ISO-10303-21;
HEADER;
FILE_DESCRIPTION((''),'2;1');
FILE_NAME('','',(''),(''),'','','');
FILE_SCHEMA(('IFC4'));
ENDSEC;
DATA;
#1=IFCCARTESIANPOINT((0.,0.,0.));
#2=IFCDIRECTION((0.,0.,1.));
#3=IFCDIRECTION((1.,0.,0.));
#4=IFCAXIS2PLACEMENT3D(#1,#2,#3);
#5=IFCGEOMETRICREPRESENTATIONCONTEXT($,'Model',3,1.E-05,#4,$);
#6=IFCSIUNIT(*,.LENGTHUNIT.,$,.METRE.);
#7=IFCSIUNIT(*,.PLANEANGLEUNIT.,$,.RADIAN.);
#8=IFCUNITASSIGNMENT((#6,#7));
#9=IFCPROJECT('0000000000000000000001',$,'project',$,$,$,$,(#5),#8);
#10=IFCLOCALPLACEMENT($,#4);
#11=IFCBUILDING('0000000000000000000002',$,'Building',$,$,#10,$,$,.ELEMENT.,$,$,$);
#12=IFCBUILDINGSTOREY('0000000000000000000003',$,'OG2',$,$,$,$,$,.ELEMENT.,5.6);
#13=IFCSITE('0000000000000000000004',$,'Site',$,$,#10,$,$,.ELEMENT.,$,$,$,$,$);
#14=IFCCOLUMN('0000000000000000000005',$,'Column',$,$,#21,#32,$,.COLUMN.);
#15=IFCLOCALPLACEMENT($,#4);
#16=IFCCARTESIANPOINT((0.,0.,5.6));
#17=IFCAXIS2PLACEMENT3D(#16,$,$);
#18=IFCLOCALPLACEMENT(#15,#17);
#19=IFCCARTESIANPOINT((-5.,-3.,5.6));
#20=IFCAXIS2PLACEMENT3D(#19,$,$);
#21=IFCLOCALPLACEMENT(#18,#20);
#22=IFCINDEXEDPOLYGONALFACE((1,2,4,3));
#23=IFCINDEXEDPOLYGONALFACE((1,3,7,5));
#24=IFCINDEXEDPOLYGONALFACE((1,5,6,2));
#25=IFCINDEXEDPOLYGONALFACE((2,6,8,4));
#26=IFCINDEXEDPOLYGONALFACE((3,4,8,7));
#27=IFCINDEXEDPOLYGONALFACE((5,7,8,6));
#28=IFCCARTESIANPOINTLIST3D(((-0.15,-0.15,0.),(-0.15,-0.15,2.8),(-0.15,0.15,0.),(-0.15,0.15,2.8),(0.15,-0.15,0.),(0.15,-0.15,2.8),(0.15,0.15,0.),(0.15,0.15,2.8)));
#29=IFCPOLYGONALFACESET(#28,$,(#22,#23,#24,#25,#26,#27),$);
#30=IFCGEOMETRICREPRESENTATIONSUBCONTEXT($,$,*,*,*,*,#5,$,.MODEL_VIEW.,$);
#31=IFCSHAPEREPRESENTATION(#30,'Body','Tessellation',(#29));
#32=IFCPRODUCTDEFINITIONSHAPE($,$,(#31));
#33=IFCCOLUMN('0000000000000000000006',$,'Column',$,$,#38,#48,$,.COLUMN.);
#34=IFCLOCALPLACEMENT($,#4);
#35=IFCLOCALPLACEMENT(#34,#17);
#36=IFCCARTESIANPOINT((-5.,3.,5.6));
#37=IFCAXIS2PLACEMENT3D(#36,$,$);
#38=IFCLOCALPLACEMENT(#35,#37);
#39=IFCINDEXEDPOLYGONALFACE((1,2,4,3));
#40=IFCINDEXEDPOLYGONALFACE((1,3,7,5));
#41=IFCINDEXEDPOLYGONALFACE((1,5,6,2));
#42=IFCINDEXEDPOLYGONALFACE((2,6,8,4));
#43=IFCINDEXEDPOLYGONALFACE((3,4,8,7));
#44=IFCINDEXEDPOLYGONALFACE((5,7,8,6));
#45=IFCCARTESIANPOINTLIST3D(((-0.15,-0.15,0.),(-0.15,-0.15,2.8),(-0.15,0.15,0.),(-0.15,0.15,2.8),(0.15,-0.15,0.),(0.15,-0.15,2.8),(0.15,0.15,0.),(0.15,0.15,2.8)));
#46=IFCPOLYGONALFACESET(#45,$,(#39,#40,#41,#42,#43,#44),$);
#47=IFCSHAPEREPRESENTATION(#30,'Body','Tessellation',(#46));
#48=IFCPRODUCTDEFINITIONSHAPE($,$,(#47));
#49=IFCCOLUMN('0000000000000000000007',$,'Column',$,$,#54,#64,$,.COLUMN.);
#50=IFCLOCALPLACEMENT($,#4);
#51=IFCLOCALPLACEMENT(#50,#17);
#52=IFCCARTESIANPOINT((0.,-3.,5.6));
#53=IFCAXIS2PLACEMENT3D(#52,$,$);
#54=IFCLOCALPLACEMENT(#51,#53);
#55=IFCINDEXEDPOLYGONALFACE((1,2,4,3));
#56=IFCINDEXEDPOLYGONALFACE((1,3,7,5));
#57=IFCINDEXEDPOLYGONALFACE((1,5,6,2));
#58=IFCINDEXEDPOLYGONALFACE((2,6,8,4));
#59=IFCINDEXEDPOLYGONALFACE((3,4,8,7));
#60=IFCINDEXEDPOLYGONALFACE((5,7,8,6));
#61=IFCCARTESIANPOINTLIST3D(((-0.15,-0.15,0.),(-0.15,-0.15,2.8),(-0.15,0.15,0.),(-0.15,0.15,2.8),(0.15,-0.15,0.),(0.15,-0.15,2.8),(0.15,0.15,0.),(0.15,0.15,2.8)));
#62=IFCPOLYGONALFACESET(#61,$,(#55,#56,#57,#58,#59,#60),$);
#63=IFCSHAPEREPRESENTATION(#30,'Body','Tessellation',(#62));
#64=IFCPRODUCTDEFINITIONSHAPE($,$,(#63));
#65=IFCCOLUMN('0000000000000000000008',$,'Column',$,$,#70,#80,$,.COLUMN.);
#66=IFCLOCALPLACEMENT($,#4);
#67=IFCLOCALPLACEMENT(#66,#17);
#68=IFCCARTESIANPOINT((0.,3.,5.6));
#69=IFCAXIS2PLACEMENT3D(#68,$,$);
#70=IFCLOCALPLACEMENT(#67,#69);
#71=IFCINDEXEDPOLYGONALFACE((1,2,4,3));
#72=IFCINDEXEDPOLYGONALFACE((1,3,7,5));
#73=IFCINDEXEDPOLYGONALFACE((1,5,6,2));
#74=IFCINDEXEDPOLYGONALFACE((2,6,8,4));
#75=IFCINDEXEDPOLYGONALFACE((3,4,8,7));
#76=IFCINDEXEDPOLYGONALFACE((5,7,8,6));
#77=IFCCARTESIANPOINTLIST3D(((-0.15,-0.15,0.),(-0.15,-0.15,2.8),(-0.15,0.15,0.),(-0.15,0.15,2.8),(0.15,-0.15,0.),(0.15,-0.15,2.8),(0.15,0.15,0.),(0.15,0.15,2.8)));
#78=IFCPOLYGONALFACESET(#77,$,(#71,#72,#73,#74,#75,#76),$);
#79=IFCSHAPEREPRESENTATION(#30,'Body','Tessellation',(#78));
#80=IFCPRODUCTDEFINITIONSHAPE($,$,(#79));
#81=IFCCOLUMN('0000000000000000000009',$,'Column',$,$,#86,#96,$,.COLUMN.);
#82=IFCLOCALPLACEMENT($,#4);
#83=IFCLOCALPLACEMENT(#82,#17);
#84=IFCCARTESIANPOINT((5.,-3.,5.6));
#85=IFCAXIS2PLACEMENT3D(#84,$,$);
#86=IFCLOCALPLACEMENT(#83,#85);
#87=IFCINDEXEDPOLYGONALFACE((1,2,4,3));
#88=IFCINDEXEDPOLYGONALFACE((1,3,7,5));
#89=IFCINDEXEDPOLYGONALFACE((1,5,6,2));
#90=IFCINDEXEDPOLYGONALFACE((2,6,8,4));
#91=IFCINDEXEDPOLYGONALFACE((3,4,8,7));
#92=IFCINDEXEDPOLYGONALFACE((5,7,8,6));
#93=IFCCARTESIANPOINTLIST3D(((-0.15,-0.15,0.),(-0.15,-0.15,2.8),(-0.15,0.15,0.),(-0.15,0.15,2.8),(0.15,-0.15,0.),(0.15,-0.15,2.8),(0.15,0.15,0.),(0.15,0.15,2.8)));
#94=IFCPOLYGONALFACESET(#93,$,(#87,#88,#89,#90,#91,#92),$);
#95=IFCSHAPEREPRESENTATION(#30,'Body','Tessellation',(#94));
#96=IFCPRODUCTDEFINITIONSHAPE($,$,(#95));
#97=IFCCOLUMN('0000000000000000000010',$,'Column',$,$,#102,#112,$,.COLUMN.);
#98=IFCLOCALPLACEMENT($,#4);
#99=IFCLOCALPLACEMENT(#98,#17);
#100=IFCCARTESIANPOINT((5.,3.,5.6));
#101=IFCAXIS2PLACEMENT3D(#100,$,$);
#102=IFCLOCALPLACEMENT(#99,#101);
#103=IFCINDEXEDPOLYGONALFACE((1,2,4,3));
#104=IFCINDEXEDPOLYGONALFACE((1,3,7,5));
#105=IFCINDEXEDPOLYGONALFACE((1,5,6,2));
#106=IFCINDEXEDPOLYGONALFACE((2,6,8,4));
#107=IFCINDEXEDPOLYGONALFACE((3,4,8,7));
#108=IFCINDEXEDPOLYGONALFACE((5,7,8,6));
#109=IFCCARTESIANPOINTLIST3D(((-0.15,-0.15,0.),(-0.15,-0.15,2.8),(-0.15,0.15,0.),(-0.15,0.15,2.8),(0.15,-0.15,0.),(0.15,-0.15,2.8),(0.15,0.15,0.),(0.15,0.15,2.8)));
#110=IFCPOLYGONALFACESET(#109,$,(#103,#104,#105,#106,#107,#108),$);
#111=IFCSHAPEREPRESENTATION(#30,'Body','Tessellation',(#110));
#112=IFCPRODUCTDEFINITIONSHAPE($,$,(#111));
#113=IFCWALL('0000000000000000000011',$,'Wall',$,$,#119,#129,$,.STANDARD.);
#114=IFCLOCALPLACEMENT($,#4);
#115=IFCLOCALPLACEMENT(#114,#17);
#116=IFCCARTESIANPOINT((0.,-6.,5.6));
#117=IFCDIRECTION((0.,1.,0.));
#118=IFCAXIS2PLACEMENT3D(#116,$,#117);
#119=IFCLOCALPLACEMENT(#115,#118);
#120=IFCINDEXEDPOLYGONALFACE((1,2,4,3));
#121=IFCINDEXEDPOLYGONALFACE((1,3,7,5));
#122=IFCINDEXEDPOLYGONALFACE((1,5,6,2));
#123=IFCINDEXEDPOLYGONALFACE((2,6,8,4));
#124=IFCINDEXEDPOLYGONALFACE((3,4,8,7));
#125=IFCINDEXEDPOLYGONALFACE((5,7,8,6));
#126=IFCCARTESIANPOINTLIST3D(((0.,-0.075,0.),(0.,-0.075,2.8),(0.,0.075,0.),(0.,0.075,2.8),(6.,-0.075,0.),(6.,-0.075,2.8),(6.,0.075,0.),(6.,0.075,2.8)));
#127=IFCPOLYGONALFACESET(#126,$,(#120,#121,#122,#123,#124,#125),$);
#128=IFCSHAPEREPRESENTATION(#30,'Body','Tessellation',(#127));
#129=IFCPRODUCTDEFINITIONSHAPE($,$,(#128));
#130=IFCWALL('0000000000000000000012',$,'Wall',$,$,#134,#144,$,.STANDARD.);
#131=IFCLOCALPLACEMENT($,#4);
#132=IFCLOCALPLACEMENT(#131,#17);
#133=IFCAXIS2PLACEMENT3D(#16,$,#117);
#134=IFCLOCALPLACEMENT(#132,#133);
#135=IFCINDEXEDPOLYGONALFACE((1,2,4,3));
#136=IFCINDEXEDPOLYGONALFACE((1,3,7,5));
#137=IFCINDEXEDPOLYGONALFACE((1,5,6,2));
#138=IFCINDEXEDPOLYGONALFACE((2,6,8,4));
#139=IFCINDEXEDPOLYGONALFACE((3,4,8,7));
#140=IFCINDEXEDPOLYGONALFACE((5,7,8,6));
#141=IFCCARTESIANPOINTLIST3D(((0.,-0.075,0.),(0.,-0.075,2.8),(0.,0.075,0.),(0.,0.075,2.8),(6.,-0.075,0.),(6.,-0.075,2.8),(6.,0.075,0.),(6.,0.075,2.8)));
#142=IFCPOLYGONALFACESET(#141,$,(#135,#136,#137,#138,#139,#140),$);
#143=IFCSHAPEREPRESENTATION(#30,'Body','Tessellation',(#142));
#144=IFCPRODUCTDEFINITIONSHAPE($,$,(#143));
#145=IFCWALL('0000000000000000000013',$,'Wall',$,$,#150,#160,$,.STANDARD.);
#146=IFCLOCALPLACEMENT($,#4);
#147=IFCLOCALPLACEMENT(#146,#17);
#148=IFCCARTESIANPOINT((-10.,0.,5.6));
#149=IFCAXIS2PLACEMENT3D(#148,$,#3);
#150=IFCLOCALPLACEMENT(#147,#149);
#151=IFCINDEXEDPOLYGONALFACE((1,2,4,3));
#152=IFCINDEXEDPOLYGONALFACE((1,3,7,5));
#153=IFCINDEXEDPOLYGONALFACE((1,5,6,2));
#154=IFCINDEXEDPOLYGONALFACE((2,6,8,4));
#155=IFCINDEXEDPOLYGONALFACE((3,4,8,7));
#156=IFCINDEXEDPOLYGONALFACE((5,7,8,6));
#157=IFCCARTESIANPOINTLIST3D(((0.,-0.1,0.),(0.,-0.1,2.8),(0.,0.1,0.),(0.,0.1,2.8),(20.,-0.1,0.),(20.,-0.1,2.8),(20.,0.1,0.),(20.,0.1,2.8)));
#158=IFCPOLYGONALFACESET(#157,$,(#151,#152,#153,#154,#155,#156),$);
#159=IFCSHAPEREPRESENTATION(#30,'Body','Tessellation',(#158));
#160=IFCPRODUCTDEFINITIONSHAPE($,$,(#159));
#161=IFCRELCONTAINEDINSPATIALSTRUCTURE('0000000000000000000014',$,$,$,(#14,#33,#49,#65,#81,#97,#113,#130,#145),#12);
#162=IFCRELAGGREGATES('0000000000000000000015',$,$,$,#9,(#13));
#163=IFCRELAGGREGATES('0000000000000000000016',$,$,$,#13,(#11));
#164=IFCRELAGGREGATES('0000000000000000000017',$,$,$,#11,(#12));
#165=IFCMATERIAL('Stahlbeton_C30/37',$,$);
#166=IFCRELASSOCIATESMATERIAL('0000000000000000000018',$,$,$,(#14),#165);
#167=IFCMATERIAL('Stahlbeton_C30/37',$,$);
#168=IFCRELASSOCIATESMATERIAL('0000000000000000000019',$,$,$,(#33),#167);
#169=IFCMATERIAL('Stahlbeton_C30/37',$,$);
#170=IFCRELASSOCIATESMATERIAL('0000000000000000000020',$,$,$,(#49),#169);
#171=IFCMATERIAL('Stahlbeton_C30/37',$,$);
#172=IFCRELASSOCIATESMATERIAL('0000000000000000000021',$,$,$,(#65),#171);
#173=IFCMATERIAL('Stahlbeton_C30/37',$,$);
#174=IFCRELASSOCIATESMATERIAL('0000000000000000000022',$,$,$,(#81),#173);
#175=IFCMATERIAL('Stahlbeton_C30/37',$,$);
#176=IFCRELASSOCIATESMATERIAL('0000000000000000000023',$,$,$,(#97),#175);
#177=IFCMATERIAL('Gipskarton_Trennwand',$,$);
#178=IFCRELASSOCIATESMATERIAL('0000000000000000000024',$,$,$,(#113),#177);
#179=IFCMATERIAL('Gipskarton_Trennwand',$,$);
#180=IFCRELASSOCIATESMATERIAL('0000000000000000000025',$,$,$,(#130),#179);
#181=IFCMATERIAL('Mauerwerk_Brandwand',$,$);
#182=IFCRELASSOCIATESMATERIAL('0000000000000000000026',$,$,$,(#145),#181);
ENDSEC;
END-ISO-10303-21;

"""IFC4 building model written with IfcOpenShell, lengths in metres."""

from ifc_helpers import new_model, si_unit, frame, frame_2d, origin, origin_with_axes, origin_2d, place, context, subcontext, project, spatial, rectangle, extrude, material, element, save


model = new_model("IFC4")

# Units and contexts
model_context = context("Model", 3, precision=1e-05, world=origin_with_axes())
sub_context = subcontext(model_context, None, None, "MODEL_VIEW")
ifc_project = project(units=[si_unit("LENGTHUNIT", "METRE"), si_unit("PLANEANGLEUNIT", "RADIAN")], contexts=[model_context])

# Site, building, storey
placement_1 = place(None, origin_with_axes())
site = spatial("IfcSite", under=ifc_project, at=placement_1, Name="Site", CompositionType="ELEMENT")
building = spatial("IfcBuilding", under=site, at=placement_1, Name="Building", CompositionType="ELEMENT")
storey = spatial("IfcBuildingStorey", under=building, Name="OG2", CompositionType="ELEMENT", Elevation=5.6)

# Columns
ifc_material_1 = material(Name="Stahlbeton_C30/37")
placement_2 = place(None, origin_with_axes())
placement_3 = place(placement_2, frame((0.0, 0.0, 5.6)))
column_1_placement = place(placement_3, frame((-5.0, -3.0, 5.6)))
element("IfcColumn", 1, at=column_1_placement, inside=storey, material=ifc_material_1, Name="Column", PredefinedType="COLUMN", context=sub_context, shape_type="SweptSolid", body=[
    extrude(rectangle(XDim=0.3, YDim=0.3, at=origin_2d()), origin(), (0.0, 0.0, 1.0), 2.8),
])
ifc_material_2 = material(Name="Stahlbeton_C30/37")
placement_4 = place(None, origin_with_axes())
placement_5 = place(placement_4, frame((0.0, 0.0, 5.6)))
column_2_placement = place(placement_5, frame((-5.0, 3.0, 5.6)))
element("IfcColumn", 2, at=column_2_placement, inside=storey, material=ifc_material_2, Name="Column", PredefinedType="COLUMN", context=sub_context, shape_type="SweptSolid", body=[
    extrude(rectangle(XDim=0.3, YDim=0.3, at=origin_2d()), origin(), (0.0, 0.0, 1.0), 2.8),
])
ifc_material_3 = material(Name="Stahlbeton_C30/37")
placement_6 = place(None, origin_with_axes())
placement_7 = place(placement_6, frame((0.0, 0.0, 5.6)))
column_3_placement = place(placement_7, frame((0.0, -3.0, 5.6)))
element("IfcColumn", 3, at=column_3_placement, inside=storey, material=ifc_material_3, Name="Column", PredefinedType="COLUMN", context=sub_context, shape_type="SweptSolid", body=[
    extrude(rectangle(XDim=0.3, YDim=0.3, at=origin_2d()), origin(), (0.0, 0.0, 1.0), 2.8),
])
ifc_material_4 = material(Name="Stahlbeton_C30/37")
placement_8 = place(None, origin_with_axes())
placement_9 = place(placement_8, frame((0.0, 0.0, 5.6)))
column_4_placement = place(placement_9, frame((0.0, 3.0, 5.6)))
element("IfcColumn", 4, at=column_4_placement, inside=storey, material=ifc_material_4, Name="Column", PredefinedType="COLUMN", context=sub_context, shape_type="SweptSolid", body=[
    extrude(rectangle(XDim=0.3, YDim=0.3, at=origin_2d()), origin(), (0.0, 0.0, 1.0), 2.8),
])
ifc_material_5 = material(Name="Stahlbeton_C30/37")
placement_10 = place(None, origin_with_axes())
placement_11 = place(placement_10, frame((0.0, 0.0, 5.6)))
column_5_placement = place(placement_11, frame((5.0, -3.0, 5.6)))
element("IfcColumn", 5, at=column_5_placement, inside=storey, material=ifc_material_5, Name="Column", PredefinedType="COLUMN", context=sub_context, shape_type="SweptSolid", body=[
    extrude(rectangle(XDim=0.3, YDim=0.3, at=origin_2d()), origin(), (0.0, 0.0, 1.0), 2.8),
])
ifc_material_6 = material(Name="Stahlbeton_C30/37")
placement_12 = place(None, origin_with_axes())
placement_13 = place(placement_12, frame((0.0, 0.0, 5.6)))
column_6_placement = place(placement_13, frame((5.0, 3.0, 5.6)))
element("IfcColumn", 6, at=column_6_placement, inside=storey, material=ifc_material_6, Name="Column", PredefinedType="COLUMN", context=sub_context, shape_type="SweptSolid", body=[
    extrude(rectangle(XDim=0.3, YDim=0.3, at=origin_2d()), origin(), (0.0, 0.0, 1.0), 2.8),
])

# Walls
ifc_material_7 = material(Name="Gipskarton_Trennwand")
placement_14 = place(None, origin_with_axes())
placement_15 = place(placement_14, frame((0.0, 0.0, 5.6)))
wall_1_placement = place(placement_15, frame((0.0, -6.0, 5.6), x_axis=(0.0, 1.0, 0.0)))
element("IfcWall", 7, at=wall_1_placement, inside=storey, material=ifc_material_7, Name="Wall", PredefinedType="STANDARD", context=sub_context, shape_type="SweptSolid", body=[
    extrude(rectangle(XDim=6.0, YDim=0.15, at=frame_2d((3.0, 0.0))), origin(), (0.0, 0.0, 1.0), 2.8),
])
ifc_material_8 = material(Name="Gipskarton_Trennwand")
placement_16 = place(None, origin_with_axes())
placement_17 = place(placement_16, frame((0.0, 0.0, 5.6)))
wall_2_placement = place(placement_17, frame((0.0, 0.0, 5.6), x_axis=(0.0, 1.0, 0.0)))
element("IfcWall", 8, at=wall_2_placement, inside=storey, material=ifc_material_8, Name="Wall", PredefinedType="STANDARD", context=sub_context, shape_type="SweptSolid", body=[
    extrude(rectangle(XDim=6.0, YDim=0.15, at=frame_2d((3.0, 0.0))), origin(), (0.0, 0.0, 1.0), 2.8),
])
ifc_material_9 = material(Name="Mauerwerk_Brandwand")
placement_18 = place(None, origin_with_axes())
placement_19 = place(placement_18, frame((0.0, 0.0, 5.6)))
wall_3_placement = place(placement_19, frame((-10.0, 0.0, 5.6), x_axis=(1.0, 0.0, 0.0)))
element("IfcWall", 9, at=wall_3_placement, inside=storey, material=ifc_material_9, Name="Wall", PredefinedType="STANDARD", context=sub_context, shape_type="SweptSolid", body=[
    extrude(rectangle(XDim=20.0, YDim=0.2, at=frame_2d((10.0, 0.0))), origin(), (0.0, 0.0, 1.0), 2.8),
])

save(model, "model.ifc")
